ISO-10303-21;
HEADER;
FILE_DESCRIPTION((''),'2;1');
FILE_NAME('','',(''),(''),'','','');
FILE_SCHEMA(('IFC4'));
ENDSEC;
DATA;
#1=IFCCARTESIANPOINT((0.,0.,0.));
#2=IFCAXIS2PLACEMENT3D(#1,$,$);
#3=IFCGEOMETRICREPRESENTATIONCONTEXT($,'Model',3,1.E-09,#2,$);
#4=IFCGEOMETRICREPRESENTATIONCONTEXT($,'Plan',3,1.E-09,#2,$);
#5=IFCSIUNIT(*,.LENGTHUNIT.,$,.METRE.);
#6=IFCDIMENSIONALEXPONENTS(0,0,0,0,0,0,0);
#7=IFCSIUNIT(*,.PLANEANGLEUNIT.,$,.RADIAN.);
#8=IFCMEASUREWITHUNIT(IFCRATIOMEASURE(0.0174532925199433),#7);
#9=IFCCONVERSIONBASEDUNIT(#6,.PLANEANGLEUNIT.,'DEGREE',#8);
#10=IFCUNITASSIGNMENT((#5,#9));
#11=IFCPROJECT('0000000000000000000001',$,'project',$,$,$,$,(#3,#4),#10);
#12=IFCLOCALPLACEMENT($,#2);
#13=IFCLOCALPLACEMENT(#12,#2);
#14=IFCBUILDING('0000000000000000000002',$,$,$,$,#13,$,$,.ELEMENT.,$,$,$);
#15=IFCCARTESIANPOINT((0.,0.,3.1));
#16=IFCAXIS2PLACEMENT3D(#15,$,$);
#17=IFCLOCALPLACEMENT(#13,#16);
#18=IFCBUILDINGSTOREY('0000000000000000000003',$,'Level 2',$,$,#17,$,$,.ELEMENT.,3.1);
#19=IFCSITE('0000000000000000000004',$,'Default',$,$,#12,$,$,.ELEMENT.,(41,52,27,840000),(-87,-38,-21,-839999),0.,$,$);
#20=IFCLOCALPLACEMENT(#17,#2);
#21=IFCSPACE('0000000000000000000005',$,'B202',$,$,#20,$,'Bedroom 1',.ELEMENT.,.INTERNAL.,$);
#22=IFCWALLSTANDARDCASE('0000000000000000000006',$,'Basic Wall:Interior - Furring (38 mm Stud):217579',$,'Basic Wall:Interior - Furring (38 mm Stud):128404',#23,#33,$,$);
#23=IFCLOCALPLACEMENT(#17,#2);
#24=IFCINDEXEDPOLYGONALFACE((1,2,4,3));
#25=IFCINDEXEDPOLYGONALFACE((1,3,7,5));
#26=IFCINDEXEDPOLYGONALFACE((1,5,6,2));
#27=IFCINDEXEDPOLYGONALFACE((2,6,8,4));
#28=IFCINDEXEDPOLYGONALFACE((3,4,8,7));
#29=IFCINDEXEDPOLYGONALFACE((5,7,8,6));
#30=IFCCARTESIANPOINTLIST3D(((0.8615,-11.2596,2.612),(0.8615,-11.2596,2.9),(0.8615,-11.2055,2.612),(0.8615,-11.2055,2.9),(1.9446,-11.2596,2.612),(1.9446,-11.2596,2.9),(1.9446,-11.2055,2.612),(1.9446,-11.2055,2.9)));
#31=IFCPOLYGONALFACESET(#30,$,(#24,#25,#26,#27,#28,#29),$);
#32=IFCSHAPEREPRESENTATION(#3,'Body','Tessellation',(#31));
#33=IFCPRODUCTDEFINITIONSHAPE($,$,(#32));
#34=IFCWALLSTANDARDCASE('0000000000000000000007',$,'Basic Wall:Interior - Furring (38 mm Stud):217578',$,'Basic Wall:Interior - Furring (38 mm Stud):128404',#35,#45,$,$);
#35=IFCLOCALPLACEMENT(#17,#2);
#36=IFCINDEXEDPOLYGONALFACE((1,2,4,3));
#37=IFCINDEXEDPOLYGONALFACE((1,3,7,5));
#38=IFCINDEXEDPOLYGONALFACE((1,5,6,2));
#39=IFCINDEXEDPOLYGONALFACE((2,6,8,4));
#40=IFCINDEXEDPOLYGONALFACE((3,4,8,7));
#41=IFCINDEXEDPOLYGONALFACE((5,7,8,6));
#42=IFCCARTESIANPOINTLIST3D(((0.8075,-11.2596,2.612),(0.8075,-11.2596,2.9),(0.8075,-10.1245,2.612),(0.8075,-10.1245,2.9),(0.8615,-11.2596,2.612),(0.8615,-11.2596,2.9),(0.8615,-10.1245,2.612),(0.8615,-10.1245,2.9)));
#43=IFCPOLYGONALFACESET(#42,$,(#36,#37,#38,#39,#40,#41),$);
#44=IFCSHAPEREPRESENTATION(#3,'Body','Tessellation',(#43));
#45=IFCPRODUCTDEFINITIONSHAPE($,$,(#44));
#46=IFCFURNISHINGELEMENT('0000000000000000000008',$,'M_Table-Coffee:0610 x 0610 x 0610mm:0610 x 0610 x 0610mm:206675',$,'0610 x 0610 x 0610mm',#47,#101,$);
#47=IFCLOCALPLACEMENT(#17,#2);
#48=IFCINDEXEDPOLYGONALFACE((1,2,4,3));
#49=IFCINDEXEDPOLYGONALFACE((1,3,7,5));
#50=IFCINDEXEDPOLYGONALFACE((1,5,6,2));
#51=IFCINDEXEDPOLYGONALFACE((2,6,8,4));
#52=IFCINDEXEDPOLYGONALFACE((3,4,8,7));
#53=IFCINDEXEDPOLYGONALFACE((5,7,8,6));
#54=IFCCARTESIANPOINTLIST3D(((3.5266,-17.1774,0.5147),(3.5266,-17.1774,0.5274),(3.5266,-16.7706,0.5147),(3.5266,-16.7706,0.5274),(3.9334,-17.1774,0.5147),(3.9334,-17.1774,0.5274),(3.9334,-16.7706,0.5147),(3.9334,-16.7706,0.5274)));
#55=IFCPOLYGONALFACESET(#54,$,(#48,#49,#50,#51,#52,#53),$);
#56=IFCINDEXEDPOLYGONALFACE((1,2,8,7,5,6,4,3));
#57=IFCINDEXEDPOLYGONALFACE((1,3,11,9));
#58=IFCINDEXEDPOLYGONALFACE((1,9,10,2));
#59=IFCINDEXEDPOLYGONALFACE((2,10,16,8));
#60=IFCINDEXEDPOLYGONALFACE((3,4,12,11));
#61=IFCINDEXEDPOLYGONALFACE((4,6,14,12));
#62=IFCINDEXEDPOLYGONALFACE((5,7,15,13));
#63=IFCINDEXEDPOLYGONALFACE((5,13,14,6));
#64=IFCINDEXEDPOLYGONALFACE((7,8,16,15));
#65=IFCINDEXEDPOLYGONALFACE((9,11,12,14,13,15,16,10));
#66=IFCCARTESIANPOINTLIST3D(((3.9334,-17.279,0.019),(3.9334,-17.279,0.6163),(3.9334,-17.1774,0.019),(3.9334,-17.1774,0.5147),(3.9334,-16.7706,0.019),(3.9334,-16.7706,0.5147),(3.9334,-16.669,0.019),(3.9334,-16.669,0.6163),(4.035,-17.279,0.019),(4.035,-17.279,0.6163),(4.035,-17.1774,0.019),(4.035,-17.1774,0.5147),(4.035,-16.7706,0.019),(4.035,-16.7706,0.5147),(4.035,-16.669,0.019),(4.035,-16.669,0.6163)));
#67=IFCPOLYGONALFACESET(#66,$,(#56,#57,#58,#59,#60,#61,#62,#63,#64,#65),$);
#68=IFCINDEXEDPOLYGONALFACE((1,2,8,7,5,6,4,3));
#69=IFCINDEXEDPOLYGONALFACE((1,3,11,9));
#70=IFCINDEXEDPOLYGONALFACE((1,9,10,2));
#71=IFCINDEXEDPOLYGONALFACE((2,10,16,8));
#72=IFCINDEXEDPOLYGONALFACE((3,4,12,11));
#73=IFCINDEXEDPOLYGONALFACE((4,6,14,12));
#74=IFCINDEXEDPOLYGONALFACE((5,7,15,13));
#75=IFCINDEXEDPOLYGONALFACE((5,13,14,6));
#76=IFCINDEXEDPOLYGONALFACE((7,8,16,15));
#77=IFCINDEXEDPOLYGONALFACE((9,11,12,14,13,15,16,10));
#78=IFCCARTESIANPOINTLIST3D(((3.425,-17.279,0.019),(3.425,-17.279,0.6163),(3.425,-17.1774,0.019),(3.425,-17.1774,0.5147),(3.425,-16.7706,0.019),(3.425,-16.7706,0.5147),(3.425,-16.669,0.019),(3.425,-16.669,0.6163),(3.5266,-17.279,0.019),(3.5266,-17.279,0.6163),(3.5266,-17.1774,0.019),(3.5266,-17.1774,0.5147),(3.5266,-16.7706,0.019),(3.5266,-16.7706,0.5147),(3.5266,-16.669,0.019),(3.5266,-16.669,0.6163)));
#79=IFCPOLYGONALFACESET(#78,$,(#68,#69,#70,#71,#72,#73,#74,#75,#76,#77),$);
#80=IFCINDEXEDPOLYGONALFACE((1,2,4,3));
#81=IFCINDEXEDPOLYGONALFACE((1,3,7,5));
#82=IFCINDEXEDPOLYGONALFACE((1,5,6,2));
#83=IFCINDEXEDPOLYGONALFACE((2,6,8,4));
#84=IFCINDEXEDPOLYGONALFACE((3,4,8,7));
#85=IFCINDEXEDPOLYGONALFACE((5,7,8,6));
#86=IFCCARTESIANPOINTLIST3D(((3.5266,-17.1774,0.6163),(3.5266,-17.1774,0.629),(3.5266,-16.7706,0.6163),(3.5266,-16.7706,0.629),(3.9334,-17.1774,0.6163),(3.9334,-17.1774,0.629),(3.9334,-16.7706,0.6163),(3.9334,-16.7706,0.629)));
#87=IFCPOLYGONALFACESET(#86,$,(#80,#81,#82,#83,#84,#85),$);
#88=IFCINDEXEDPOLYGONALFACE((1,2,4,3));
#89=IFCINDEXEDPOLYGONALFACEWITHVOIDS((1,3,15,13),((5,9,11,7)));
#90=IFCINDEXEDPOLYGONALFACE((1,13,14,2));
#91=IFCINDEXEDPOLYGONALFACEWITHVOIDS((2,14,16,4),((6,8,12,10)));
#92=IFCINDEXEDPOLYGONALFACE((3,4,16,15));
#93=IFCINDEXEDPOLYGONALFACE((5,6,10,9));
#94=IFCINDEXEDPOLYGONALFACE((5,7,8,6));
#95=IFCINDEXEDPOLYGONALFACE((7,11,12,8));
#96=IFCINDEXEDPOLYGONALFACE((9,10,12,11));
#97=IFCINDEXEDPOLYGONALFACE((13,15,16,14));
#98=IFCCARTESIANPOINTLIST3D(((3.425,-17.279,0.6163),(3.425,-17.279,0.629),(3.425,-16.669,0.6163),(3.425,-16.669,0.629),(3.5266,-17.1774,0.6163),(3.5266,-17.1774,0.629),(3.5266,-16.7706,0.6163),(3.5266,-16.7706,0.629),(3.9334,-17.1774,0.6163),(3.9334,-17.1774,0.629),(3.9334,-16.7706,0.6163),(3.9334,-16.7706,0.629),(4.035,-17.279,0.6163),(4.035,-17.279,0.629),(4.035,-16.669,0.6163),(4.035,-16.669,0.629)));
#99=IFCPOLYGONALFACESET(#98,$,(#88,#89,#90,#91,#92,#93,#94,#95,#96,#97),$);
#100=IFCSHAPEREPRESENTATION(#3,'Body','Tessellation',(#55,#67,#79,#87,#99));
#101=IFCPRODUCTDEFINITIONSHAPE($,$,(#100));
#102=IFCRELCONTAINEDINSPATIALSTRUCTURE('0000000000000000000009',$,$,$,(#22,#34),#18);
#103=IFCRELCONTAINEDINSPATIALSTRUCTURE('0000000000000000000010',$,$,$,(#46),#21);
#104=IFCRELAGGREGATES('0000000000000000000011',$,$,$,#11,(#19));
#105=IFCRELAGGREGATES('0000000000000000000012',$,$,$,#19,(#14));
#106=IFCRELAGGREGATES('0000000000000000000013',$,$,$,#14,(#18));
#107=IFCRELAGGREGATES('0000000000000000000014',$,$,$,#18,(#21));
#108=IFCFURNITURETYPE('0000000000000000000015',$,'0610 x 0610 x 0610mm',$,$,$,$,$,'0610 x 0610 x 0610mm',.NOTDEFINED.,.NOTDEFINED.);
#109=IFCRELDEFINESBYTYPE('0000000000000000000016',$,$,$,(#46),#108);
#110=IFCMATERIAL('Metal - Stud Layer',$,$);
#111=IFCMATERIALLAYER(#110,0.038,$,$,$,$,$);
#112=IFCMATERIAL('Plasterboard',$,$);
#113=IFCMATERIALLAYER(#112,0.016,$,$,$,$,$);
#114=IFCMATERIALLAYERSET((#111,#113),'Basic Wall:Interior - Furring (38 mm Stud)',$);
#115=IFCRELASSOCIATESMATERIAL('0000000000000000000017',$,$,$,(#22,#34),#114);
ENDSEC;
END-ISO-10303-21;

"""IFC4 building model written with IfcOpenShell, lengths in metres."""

from ifc_helpers import new_model, entity, si_unit, converted_unit, frame, frame_2d, origin, origin_2d_with_axis, place, context, project, spatial, polyline, rectangle, outline, extrude, source, transform, mapped, material, layer, layer_set, layer_usage, type_object, type_shapes, element, save


model = new_model("IFC4")

# Units and contexts
model_context = context("Model", 3, precision=1e-09, world=origin())
plan_context = context("Plan", 3, precision=1e-09, world=origin())
ifc_project = project(units=[si_unit("LENGTHUNIT", "METRE"), converted_unit("PLANEANGLEUNIT", "DEGREE", entity("IfcRatioMeasure", 0.0174532925199433), si_unit("PLANEANGLEUNIT", "RADIAN"), dimensions=[0, 0, 0, 0, 0, 0, 0])], contexts=[model_context, plan_context])

# Site, building, storey
site_placement = place(None, origin())
site = spatial("IfcSite", under=ifc_project, at=site_placement, Name="Default", CompositionType="ELEMENT", RefLatitude=(41, 52, 27, 840000), RefLongitude=(-87, -38, -21, -839999), RefElevation=0.0)
building_placement = place(site_placement, origin())
building = spatial("IfcBuilding", under=site, at=building_placement, CompositionType="ELEMENT")
storey_placement = place(building_placement, frame((0.0, 0.0, 3.1)))
storey = spatial("IfcBuildingStorey", under=building, at=storey_placement, Name="Level 2", CompositionType="ELEMENT", Elevation=3.1)

# Shared definitions
ifc_material_1 = material(Name="Metal - Stud Layer")
ifc_material_2 = material(Name="Plasterboard")

# Walls
ifc_layer_1 = layer(ifc_material_1, 0.038)
ifc_layer_2 = layer(ifc_material_2, 0.016)
ifc_layer_set_1 = layer_set([ifc_layer_1, ifc_layer_2], Name="Basic Wall:Interior - Furring (38 mm Stud)")
ifc_layer_usage_1 = layer_usage(ifc_layer_set_1, "AXIS2", "NEGATIVE", 0.027)
wall_1_placement = place(storey_placement, frame((1.9446, -11.2325, 2.612), z_axis=(0.0, 0.0, 1.0), x_axis=(-1.0, 0.0, 0.0)))
element("IfcWallStandardCase", 1, at=wall_1_placement, inside=storey, material=ifc_layer_usage_1, Name="Basic Wall:Interior - Furring (38 mm Stud):217579", ObjectType="Basic Wall:Interior - Furring (38 mm Stud):128404", context=model_context, shape_type="SweptSolid", body=[
    extrude(rectangle(XDim=1.0831, YDim=0.054, at=frame_2d((0.5415, 0.0), x_axis=(-1.0, 0.0))), origin(), (0.0, 0.0, 1.0), 0.288),
])
ifc_layer_usage_2 = layer_usage(ifc_layer_set_1, "AXIS2", "NEGATIVE", 0.027)
wall_2_placement = place(storey_placement, frame((0.8345, -11.2596, 2.612), z_axis=(0.0, 0.0, 1.0), x_axis=(0.0, 1.0, 0.0)))
element("IfcWallStandardCase", 2, at=wall_2_placement, inside=storey, material=ifc_layer_usage_2, Name="Basic Wall:Interior - Furring (38 mm Stud):217578", ObjectType="Basic Wall:Interior - Furring (38 mm Stud):128404", context=model_context, shape_type="SweptSolid", body=[
    extrude(rectangle(XDim=1.1351, YDim=0.054, at=frame_2d((0.5675, 0.0), x_axis=(-1.0, 0.0))), origin(), (0.0, 0.0, 1.0), 0.288),
])

# Shared definitions
space_placement = place(storey_placement, origin())
space = spatial("IfcSpace", under=storey, at=space_placement, Name="B202", LongName="Bedroom 1", CompositionType="ELEMENT", PredefinedType="INTERNAL")

# Furnishing element
furniture_type = type_object("IfcFurnitureType", Name="0610 x 0610 x 0610mm", ElementType="0610 x 0610 x 0610mm", AssemblyPlace="NOTDEFINED")
shared_shape_1 = source(origin(), model_context, "Body", "SweptSolid", [
    extrude(rectangle(XDim=0.4068, YDim=0.4068, at=origin_2d_with_axis()), frame((0.0183, 0.0952, 0.4957), z_axis=(0.0, 0.0, 1.0), x_axis=(-1.0, 0.0, 0.0)), (0.0, 0.0, 1.0), 0.0127),
    extrude(outline(polyline([(-0.2732, -0.305), (0.324, -0.305), (0.324, 0.305), (-0.2732, 0.305), (-0.2732, 0.2034), (0.2225, 0.2034), (0.2225, -0.2034), (-0.2732, -0.2034), (-0.2732, -0.305)])), frame((0.2217, 0.0952, 0.2732), z_axis=(1.0, 0.0, 0.0), x_axis=(0.0, 0.0, 1.0)), (0.0, 0.0, 1.0), 0.1016),
    extrude(outline(polyline([(-0.305, -0.3241), (0.305, -0.3241), (0.305, 0.2733), (0.2034, 0.2733), (0.2034, -0.2224), (-0.2034, -0.2224), (-0.2034, 0.2733), (-0.305, 0.2733), (-0.305, -0.3241)])), frame((-0.2867, 0.0952, 0.2733), z_axis=(1.0, 0.0, 0.0), x_axis=(0.0, -1.0, 0.0)), (0.0, 0.0, 1.0), 0.1016),
    extrude(rectangle(XDim=0.4068, YDim=0.4068, at=origin_2d_with_axis()), frame((0.0183, 0.0952, 0.5973), z_axis=(0.0, 0.0, 1.0), x_axis=(-1.0, 0.0, 0.0)), (0.0, 0.0, 1.0), 0.0127),
    extrude(outline(polyline([(-0.305, -0.305), (0.305, -0.305), (0.305, 0.305), (-0.305, 0.305), (-0.305, -0.305)]), holes=[polyline([(-0.2034, -0.2034), (-0.2034, 0.2034), (0.2034, 0.2034), (0.2034, -0.2034), (-0.2034, -0.2034)])]), frame((0.0183, 0.0952, 0.5973), z_axis=(0.0, 0.0, 1.0), x_axis=(-1.0, 0.0, 0.0)), (0.0, 0.0, 1.0), 0.0127),
])
type_shapes(furniture_type, [shared_shape_1])
furnishing_placement = place(space_placement, frame((3.7117, -17.0692, 0.019)))
element("IfcFurnishingElement", 3, at=furnishing_placement, inside=space, type_object=furniture_type, Name="M_Table-Coffee:0610 x 0610 x 0610mm:0610 x 0610 x 0610mm:206675", ObjectType="0610 x 0610 x 0610mm", context=model_context, shape_type="MappedRepresentation", body=[
    mapped(shared_shape_1, transform((0.0, 0.0, 0.0), scale=1.0)),
])

save(model, "model.ifc")
